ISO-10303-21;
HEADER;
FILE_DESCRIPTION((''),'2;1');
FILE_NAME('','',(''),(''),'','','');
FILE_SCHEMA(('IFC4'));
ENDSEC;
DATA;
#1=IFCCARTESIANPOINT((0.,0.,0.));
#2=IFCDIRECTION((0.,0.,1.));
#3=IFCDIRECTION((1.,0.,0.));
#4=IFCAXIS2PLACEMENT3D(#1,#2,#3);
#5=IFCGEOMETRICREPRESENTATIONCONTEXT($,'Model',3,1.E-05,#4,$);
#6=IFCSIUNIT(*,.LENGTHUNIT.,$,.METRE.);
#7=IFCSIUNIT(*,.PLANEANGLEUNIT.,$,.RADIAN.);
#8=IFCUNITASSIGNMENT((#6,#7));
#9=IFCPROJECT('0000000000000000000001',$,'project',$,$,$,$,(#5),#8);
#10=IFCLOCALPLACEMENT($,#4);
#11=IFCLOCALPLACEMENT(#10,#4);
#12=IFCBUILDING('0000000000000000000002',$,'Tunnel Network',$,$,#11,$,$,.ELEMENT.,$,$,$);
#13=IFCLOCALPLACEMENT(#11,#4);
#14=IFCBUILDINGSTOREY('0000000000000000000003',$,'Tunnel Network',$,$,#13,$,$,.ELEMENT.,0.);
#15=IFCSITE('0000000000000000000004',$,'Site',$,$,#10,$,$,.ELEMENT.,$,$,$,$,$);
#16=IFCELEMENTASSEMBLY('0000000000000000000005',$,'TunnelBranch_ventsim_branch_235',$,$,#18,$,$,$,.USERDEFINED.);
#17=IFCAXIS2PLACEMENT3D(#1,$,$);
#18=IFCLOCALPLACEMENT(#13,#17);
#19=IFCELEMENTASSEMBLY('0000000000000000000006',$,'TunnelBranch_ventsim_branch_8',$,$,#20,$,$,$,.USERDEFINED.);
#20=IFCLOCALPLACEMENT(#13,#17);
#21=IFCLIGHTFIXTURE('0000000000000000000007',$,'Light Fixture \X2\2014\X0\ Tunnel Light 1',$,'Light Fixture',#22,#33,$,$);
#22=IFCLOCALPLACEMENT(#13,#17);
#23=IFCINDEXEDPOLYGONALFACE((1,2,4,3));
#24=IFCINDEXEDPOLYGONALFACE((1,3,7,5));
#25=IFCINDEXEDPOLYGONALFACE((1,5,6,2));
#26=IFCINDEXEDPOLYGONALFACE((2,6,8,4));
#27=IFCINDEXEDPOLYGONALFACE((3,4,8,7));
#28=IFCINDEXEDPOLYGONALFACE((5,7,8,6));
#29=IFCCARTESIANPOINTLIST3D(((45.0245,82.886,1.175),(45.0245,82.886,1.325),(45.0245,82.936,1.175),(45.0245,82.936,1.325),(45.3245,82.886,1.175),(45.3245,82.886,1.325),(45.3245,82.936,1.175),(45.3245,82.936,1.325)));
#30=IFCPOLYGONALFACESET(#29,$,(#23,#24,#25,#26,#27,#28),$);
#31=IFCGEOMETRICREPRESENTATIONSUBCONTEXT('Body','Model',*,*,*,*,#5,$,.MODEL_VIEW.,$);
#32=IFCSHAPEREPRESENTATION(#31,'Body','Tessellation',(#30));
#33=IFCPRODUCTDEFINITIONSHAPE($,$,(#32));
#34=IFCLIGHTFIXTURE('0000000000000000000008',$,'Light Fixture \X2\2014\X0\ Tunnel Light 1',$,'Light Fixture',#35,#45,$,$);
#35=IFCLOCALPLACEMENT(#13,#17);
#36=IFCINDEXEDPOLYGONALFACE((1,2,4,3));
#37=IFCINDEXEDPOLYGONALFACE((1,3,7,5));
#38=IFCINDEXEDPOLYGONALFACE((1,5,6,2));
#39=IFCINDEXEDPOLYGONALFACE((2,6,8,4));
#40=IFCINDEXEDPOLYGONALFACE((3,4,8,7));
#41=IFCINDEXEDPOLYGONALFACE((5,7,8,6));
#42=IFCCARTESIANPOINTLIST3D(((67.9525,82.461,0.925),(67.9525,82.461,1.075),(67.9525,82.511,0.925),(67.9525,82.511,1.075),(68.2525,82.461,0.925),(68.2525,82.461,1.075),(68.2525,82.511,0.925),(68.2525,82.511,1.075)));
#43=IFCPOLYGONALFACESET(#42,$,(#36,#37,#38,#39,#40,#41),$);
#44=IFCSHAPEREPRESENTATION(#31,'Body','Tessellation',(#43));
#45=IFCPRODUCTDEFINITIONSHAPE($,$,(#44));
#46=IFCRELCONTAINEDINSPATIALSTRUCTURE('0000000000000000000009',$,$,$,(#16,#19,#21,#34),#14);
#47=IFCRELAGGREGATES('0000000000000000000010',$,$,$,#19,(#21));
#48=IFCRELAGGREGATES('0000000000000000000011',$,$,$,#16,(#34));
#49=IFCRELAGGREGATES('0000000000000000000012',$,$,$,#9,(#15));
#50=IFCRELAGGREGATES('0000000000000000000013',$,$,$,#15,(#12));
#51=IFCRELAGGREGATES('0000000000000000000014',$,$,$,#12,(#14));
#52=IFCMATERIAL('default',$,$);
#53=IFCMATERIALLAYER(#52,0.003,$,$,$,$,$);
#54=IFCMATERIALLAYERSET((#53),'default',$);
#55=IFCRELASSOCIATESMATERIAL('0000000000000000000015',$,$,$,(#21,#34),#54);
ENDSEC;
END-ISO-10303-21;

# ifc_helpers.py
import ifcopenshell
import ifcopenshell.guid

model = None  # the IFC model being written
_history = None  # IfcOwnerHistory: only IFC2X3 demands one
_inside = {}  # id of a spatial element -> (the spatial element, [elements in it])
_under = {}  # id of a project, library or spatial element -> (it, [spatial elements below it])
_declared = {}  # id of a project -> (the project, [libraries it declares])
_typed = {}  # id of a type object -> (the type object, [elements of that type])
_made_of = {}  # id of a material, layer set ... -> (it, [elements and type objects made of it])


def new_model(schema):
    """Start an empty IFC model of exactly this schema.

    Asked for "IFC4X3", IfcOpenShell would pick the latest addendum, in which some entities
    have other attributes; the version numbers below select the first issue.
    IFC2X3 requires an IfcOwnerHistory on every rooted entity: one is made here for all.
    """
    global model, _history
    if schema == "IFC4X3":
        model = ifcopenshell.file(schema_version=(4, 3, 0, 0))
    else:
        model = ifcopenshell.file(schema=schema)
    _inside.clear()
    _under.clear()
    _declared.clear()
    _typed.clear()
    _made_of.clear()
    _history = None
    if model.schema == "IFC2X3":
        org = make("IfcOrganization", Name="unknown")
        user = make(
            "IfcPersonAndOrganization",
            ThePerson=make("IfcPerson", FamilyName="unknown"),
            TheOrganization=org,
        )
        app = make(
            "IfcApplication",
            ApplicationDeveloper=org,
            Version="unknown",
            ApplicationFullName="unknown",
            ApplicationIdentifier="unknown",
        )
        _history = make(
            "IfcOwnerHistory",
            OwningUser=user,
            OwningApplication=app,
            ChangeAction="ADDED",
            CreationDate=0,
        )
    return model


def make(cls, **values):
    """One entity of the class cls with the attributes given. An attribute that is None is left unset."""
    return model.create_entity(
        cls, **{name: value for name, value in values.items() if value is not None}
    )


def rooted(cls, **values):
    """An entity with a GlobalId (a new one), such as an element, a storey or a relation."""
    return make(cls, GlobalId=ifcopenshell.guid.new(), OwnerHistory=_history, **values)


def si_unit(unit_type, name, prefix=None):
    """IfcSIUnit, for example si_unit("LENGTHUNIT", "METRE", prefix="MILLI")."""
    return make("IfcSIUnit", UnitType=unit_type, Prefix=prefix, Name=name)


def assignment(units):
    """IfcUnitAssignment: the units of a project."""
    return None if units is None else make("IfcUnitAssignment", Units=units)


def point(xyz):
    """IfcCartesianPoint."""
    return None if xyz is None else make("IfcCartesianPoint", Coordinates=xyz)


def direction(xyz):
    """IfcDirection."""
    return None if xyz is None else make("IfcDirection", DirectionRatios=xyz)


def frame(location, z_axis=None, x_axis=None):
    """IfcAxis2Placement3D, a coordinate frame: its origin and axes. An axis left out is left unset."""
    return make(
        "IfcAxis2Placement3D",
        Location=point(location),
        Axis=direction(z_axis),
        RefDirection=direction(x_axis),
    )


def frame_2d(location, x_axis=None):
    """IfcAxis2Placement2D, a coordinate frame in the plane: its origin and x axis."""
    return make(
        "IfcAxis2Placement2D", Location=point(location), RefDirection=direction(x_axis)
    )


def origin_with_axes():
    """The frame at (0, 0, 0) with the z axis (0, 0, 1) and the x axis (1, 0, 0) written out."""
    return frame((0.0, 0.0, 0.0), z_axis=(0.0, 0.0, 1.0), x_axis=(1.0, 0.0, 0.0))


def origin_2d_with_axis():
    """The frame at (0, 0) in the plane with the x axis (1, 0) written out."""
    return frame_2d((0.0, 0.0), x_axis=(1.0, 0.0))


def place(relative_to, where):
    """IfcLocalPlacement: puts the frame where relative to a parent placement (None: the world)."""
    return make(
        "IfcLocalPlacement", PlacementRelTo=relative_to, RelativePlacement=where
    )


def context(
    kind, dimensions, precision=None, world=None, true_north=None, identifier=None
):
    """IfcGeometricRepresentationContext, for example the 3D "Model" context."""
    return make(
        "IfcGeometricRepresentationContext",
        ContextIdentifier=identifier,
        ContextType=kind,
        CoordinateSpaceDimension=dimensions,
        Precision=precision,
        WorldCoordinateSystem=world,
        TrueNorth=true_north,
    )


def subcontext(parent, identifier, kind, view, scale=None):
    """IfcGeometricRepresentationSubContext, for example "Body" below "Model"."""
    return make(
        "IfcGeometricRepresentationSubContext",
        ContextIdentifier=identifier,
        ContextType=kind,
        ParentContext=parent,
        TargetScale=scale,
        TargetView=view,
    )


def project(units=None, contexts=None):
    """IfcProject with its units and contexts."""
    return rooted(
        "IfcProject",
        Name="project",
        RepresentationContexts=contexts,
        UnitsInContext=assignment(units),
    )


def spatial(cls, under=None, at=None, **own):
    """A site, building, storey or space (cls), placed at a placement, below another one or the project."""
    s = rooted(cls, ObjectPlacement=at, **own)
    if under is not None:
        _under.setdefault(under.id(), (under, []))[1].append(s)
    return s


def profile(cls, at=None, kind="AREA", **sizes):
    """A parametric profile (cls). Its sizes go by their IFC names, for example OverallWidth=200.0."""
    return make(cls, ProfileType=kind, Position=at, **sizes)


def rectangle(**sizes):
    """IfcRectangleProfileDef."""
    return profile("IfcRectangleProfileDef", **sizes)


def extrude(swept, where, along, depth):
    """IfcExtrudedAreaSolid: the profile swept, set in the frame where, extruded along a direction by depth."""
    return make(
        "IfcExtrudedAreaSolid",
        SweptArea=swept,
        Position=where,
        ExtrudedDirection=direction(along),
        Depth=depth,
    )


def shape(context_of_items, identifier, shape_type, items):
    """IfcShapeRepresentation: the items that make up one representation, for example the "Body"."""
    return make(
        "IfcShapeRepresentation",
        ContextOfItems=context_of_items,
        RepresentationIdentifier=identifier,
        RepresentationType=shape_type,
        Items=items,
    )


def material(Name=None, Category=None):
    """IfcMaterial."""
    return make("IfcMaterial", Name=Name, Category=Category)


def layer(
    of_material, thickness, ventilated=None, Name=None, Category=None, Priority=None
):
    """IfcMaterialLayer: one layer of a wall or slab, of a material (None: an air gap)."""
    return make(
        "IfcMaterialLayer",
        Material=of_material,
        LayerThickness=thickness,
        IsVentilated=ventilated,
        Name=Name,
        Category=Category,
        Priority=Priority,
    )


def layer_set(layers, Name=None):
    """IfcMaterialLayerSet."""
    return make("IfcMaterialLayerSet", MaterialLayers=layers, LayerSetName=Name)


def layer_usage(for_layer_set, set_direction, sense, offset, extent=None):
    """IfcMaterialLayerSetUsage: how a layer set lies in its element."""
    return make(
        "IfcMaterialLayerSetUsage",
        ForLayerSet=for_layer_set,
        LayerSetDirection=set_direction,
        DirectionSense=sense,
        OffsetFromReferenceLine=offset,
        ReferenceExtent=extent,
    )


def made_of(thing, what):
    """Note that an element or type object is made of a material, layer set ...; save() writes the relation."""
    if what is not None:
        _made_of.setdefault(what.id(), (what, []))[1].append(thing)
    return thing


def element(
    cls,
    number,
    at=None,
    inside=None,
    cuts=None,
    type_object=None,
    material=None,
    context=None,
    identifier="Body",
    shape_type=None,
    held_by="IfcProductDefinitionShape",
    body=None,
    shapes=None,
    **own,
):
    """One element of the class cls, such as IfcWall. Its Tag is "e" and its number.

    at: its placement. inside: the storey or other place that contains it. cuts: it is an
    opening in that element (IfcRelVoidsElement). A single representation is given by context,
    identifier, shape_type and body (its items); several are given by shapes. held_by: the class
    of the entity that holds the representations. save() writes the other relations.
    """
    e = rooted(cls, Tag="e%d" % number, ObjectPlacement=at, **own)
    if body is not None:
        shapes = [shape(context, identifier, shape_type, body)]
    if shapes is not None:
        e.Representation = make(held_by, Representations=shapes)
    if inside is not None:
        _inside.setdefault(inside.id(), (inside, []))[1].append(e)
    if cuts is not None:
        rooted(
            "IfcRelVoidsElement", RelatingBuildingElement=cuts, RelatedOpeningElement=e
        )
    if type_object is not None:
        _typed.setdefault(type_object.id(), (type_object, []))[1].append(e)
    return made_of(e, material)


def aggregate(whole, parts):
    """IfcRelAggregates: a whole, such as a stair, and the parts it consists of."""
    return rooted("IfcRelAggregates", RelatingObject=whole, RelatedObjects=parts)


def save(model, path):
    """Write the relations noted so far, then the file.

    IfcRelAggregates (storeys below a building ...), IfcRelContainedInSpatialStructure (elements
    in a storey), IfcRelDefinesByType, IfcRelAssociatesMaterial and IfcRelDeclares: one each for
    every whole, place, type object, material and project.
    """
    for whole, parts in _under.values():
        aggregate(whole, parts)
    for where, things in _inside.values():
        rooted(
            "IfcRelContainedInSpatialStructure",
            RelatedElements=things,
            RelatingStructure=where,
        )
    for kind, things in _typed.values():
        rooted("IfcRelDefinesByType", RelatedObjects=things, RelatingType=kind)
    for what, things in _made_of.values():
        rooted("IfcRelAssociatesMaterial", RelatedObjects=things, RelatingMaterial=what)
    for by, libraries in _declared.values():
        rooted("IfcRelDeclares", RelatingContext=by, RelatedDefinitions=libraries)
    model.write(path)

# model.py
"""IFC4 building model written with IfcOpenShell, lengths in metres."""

from ifc_helpers import new_model, si_unit, frame, origin_with_axes, origin_2d_with_axis, place, context, subcontext, project, spatial, rectangle, extrude, material, layer, layer_set, layer_usage, element, aggregate, save


model = new_model("IFC4")

# Units and contexts
model_context = context("Model", 3, precision=1e-05, world=origin_with_axes())
body_context = subcontext(model_context, "Body", "Model", "MODEL_VIEW")
ifc_project = project(units=[si_unit("LENGTHUNIT", "METRE"), si_unit("PLANEANGLEUNIT", "RADIAN")], contexts=[model_context])

# Site, building, storey
site_placement = place(None, origin_with_axes())
site = spatial("IfcSite", under=ifc_project, at=site_placement, Name="Site", CompositionType="ELEMENT")
building_placement = place(site_placement, origin_with_axes())
building = spatial("IfcBuilding", under=site, at=building_placement, Name="Tunnel Network", CompositionType="ELEMENT")
storey_placement = place(building_placement, origin_with_axes())
storey = spatial("IfcBuildingStorey", under=building, at=storey_placement, Name="Tunnel Network", CompositionType="ELEMENT", Elevation=0.0)

# Element assembly
ifc_material_1 = material(Name="default")
ifc_layer_1 = layer(ifc_material_1, 0.003)
ifc_layer_set_1 = layer_set([ifc_layer_1], Name="default")
assembly_1_placement = place(storey_placement, frame((68.1025, 82.461, 1.0), z_axis=(0.0, 1.0, 0.0), x_axis=(-1.0, 0.0, 0.0)))
assembly_1 = element("IfcElementAssembly", 1, at=assembly_1_placement, inside=storey, Name="TunnelBranch_ventsim_branch_235", PredefinedType="USERDEFINED")

# Element assembly, light fixture
assembly_2_placement = place(storey_placement, frame((47.6745, 80.761, 43.5572), z_axis=(0.0, 1.0, 0.0), x_axis=(-1.0, 0.0, 0.0)))
assembly_2 = element("IfcElementAssembly", 2, at=assembly_2_placement, inside=storey, Name="TunnelBranch_ventsim_branch_8", PredefinedType="USERDEFINED")
ifc_layer_usage_1 = layer_usage(ifc_layer_set_1, "AXIS2", "POSITIVE", 0.0)
light_fixture_1_placement = place(storey_placement, frame((45.1745, 82.886, 1.25), z_axis=(0.0, 1.0, 0.0), x_axis=(-1.0, 0.0, 0.0)))
light_fixture_1 = element("IfcLightFixture", 3, at=light_fixture_1_placement, inside=storey, material=ifc_layer_usage_1, Name="Light Fixture — Tunnel Light 1", ObjectType="Light Fixture", context=body_context, shape_type="SweptSolid", body=[
    extrude(rectangle(XDim=0.3, YDim=0.15, at=origin_2d_with_axis()), origin_with_axes(), (0.0, 0.0, 1.0), 0.05),
])
aggregate(assembly_2, [light_fixture_1])

# Light fixture
ifc_layer_usage_2 = layer_usage(ifc_layer_set_1, "AXIS2", "POSITIVE", 0.0)
light_fixture_2_placement = place(storey_placement, frame((68.1025, 82.461, 1.0), z_axis=(0.0, 1.0, 0.0), x_axis=(-1.0, 0.0, 0.0)))
light_fixture_2 = element("IfcLightFixture", 4, at=light_fixture_2_placement, inside=storey, material=ifc_layer_usage_2, Name="Light Fixture — Tunnel Light 1", ObjectType="Light Fixture", context=body_context, shape_type="SweptSolid", body=[
    extrude(rectangle(XDim=0.3, YDim=0.15, at=origin_2d_with_axis()), origin_with_axes(), (0.0, 0.0, 1.0), 0.05),
])
aggregate(assembly_1, [light_fixture_2])

save(model, "model.ifc")
